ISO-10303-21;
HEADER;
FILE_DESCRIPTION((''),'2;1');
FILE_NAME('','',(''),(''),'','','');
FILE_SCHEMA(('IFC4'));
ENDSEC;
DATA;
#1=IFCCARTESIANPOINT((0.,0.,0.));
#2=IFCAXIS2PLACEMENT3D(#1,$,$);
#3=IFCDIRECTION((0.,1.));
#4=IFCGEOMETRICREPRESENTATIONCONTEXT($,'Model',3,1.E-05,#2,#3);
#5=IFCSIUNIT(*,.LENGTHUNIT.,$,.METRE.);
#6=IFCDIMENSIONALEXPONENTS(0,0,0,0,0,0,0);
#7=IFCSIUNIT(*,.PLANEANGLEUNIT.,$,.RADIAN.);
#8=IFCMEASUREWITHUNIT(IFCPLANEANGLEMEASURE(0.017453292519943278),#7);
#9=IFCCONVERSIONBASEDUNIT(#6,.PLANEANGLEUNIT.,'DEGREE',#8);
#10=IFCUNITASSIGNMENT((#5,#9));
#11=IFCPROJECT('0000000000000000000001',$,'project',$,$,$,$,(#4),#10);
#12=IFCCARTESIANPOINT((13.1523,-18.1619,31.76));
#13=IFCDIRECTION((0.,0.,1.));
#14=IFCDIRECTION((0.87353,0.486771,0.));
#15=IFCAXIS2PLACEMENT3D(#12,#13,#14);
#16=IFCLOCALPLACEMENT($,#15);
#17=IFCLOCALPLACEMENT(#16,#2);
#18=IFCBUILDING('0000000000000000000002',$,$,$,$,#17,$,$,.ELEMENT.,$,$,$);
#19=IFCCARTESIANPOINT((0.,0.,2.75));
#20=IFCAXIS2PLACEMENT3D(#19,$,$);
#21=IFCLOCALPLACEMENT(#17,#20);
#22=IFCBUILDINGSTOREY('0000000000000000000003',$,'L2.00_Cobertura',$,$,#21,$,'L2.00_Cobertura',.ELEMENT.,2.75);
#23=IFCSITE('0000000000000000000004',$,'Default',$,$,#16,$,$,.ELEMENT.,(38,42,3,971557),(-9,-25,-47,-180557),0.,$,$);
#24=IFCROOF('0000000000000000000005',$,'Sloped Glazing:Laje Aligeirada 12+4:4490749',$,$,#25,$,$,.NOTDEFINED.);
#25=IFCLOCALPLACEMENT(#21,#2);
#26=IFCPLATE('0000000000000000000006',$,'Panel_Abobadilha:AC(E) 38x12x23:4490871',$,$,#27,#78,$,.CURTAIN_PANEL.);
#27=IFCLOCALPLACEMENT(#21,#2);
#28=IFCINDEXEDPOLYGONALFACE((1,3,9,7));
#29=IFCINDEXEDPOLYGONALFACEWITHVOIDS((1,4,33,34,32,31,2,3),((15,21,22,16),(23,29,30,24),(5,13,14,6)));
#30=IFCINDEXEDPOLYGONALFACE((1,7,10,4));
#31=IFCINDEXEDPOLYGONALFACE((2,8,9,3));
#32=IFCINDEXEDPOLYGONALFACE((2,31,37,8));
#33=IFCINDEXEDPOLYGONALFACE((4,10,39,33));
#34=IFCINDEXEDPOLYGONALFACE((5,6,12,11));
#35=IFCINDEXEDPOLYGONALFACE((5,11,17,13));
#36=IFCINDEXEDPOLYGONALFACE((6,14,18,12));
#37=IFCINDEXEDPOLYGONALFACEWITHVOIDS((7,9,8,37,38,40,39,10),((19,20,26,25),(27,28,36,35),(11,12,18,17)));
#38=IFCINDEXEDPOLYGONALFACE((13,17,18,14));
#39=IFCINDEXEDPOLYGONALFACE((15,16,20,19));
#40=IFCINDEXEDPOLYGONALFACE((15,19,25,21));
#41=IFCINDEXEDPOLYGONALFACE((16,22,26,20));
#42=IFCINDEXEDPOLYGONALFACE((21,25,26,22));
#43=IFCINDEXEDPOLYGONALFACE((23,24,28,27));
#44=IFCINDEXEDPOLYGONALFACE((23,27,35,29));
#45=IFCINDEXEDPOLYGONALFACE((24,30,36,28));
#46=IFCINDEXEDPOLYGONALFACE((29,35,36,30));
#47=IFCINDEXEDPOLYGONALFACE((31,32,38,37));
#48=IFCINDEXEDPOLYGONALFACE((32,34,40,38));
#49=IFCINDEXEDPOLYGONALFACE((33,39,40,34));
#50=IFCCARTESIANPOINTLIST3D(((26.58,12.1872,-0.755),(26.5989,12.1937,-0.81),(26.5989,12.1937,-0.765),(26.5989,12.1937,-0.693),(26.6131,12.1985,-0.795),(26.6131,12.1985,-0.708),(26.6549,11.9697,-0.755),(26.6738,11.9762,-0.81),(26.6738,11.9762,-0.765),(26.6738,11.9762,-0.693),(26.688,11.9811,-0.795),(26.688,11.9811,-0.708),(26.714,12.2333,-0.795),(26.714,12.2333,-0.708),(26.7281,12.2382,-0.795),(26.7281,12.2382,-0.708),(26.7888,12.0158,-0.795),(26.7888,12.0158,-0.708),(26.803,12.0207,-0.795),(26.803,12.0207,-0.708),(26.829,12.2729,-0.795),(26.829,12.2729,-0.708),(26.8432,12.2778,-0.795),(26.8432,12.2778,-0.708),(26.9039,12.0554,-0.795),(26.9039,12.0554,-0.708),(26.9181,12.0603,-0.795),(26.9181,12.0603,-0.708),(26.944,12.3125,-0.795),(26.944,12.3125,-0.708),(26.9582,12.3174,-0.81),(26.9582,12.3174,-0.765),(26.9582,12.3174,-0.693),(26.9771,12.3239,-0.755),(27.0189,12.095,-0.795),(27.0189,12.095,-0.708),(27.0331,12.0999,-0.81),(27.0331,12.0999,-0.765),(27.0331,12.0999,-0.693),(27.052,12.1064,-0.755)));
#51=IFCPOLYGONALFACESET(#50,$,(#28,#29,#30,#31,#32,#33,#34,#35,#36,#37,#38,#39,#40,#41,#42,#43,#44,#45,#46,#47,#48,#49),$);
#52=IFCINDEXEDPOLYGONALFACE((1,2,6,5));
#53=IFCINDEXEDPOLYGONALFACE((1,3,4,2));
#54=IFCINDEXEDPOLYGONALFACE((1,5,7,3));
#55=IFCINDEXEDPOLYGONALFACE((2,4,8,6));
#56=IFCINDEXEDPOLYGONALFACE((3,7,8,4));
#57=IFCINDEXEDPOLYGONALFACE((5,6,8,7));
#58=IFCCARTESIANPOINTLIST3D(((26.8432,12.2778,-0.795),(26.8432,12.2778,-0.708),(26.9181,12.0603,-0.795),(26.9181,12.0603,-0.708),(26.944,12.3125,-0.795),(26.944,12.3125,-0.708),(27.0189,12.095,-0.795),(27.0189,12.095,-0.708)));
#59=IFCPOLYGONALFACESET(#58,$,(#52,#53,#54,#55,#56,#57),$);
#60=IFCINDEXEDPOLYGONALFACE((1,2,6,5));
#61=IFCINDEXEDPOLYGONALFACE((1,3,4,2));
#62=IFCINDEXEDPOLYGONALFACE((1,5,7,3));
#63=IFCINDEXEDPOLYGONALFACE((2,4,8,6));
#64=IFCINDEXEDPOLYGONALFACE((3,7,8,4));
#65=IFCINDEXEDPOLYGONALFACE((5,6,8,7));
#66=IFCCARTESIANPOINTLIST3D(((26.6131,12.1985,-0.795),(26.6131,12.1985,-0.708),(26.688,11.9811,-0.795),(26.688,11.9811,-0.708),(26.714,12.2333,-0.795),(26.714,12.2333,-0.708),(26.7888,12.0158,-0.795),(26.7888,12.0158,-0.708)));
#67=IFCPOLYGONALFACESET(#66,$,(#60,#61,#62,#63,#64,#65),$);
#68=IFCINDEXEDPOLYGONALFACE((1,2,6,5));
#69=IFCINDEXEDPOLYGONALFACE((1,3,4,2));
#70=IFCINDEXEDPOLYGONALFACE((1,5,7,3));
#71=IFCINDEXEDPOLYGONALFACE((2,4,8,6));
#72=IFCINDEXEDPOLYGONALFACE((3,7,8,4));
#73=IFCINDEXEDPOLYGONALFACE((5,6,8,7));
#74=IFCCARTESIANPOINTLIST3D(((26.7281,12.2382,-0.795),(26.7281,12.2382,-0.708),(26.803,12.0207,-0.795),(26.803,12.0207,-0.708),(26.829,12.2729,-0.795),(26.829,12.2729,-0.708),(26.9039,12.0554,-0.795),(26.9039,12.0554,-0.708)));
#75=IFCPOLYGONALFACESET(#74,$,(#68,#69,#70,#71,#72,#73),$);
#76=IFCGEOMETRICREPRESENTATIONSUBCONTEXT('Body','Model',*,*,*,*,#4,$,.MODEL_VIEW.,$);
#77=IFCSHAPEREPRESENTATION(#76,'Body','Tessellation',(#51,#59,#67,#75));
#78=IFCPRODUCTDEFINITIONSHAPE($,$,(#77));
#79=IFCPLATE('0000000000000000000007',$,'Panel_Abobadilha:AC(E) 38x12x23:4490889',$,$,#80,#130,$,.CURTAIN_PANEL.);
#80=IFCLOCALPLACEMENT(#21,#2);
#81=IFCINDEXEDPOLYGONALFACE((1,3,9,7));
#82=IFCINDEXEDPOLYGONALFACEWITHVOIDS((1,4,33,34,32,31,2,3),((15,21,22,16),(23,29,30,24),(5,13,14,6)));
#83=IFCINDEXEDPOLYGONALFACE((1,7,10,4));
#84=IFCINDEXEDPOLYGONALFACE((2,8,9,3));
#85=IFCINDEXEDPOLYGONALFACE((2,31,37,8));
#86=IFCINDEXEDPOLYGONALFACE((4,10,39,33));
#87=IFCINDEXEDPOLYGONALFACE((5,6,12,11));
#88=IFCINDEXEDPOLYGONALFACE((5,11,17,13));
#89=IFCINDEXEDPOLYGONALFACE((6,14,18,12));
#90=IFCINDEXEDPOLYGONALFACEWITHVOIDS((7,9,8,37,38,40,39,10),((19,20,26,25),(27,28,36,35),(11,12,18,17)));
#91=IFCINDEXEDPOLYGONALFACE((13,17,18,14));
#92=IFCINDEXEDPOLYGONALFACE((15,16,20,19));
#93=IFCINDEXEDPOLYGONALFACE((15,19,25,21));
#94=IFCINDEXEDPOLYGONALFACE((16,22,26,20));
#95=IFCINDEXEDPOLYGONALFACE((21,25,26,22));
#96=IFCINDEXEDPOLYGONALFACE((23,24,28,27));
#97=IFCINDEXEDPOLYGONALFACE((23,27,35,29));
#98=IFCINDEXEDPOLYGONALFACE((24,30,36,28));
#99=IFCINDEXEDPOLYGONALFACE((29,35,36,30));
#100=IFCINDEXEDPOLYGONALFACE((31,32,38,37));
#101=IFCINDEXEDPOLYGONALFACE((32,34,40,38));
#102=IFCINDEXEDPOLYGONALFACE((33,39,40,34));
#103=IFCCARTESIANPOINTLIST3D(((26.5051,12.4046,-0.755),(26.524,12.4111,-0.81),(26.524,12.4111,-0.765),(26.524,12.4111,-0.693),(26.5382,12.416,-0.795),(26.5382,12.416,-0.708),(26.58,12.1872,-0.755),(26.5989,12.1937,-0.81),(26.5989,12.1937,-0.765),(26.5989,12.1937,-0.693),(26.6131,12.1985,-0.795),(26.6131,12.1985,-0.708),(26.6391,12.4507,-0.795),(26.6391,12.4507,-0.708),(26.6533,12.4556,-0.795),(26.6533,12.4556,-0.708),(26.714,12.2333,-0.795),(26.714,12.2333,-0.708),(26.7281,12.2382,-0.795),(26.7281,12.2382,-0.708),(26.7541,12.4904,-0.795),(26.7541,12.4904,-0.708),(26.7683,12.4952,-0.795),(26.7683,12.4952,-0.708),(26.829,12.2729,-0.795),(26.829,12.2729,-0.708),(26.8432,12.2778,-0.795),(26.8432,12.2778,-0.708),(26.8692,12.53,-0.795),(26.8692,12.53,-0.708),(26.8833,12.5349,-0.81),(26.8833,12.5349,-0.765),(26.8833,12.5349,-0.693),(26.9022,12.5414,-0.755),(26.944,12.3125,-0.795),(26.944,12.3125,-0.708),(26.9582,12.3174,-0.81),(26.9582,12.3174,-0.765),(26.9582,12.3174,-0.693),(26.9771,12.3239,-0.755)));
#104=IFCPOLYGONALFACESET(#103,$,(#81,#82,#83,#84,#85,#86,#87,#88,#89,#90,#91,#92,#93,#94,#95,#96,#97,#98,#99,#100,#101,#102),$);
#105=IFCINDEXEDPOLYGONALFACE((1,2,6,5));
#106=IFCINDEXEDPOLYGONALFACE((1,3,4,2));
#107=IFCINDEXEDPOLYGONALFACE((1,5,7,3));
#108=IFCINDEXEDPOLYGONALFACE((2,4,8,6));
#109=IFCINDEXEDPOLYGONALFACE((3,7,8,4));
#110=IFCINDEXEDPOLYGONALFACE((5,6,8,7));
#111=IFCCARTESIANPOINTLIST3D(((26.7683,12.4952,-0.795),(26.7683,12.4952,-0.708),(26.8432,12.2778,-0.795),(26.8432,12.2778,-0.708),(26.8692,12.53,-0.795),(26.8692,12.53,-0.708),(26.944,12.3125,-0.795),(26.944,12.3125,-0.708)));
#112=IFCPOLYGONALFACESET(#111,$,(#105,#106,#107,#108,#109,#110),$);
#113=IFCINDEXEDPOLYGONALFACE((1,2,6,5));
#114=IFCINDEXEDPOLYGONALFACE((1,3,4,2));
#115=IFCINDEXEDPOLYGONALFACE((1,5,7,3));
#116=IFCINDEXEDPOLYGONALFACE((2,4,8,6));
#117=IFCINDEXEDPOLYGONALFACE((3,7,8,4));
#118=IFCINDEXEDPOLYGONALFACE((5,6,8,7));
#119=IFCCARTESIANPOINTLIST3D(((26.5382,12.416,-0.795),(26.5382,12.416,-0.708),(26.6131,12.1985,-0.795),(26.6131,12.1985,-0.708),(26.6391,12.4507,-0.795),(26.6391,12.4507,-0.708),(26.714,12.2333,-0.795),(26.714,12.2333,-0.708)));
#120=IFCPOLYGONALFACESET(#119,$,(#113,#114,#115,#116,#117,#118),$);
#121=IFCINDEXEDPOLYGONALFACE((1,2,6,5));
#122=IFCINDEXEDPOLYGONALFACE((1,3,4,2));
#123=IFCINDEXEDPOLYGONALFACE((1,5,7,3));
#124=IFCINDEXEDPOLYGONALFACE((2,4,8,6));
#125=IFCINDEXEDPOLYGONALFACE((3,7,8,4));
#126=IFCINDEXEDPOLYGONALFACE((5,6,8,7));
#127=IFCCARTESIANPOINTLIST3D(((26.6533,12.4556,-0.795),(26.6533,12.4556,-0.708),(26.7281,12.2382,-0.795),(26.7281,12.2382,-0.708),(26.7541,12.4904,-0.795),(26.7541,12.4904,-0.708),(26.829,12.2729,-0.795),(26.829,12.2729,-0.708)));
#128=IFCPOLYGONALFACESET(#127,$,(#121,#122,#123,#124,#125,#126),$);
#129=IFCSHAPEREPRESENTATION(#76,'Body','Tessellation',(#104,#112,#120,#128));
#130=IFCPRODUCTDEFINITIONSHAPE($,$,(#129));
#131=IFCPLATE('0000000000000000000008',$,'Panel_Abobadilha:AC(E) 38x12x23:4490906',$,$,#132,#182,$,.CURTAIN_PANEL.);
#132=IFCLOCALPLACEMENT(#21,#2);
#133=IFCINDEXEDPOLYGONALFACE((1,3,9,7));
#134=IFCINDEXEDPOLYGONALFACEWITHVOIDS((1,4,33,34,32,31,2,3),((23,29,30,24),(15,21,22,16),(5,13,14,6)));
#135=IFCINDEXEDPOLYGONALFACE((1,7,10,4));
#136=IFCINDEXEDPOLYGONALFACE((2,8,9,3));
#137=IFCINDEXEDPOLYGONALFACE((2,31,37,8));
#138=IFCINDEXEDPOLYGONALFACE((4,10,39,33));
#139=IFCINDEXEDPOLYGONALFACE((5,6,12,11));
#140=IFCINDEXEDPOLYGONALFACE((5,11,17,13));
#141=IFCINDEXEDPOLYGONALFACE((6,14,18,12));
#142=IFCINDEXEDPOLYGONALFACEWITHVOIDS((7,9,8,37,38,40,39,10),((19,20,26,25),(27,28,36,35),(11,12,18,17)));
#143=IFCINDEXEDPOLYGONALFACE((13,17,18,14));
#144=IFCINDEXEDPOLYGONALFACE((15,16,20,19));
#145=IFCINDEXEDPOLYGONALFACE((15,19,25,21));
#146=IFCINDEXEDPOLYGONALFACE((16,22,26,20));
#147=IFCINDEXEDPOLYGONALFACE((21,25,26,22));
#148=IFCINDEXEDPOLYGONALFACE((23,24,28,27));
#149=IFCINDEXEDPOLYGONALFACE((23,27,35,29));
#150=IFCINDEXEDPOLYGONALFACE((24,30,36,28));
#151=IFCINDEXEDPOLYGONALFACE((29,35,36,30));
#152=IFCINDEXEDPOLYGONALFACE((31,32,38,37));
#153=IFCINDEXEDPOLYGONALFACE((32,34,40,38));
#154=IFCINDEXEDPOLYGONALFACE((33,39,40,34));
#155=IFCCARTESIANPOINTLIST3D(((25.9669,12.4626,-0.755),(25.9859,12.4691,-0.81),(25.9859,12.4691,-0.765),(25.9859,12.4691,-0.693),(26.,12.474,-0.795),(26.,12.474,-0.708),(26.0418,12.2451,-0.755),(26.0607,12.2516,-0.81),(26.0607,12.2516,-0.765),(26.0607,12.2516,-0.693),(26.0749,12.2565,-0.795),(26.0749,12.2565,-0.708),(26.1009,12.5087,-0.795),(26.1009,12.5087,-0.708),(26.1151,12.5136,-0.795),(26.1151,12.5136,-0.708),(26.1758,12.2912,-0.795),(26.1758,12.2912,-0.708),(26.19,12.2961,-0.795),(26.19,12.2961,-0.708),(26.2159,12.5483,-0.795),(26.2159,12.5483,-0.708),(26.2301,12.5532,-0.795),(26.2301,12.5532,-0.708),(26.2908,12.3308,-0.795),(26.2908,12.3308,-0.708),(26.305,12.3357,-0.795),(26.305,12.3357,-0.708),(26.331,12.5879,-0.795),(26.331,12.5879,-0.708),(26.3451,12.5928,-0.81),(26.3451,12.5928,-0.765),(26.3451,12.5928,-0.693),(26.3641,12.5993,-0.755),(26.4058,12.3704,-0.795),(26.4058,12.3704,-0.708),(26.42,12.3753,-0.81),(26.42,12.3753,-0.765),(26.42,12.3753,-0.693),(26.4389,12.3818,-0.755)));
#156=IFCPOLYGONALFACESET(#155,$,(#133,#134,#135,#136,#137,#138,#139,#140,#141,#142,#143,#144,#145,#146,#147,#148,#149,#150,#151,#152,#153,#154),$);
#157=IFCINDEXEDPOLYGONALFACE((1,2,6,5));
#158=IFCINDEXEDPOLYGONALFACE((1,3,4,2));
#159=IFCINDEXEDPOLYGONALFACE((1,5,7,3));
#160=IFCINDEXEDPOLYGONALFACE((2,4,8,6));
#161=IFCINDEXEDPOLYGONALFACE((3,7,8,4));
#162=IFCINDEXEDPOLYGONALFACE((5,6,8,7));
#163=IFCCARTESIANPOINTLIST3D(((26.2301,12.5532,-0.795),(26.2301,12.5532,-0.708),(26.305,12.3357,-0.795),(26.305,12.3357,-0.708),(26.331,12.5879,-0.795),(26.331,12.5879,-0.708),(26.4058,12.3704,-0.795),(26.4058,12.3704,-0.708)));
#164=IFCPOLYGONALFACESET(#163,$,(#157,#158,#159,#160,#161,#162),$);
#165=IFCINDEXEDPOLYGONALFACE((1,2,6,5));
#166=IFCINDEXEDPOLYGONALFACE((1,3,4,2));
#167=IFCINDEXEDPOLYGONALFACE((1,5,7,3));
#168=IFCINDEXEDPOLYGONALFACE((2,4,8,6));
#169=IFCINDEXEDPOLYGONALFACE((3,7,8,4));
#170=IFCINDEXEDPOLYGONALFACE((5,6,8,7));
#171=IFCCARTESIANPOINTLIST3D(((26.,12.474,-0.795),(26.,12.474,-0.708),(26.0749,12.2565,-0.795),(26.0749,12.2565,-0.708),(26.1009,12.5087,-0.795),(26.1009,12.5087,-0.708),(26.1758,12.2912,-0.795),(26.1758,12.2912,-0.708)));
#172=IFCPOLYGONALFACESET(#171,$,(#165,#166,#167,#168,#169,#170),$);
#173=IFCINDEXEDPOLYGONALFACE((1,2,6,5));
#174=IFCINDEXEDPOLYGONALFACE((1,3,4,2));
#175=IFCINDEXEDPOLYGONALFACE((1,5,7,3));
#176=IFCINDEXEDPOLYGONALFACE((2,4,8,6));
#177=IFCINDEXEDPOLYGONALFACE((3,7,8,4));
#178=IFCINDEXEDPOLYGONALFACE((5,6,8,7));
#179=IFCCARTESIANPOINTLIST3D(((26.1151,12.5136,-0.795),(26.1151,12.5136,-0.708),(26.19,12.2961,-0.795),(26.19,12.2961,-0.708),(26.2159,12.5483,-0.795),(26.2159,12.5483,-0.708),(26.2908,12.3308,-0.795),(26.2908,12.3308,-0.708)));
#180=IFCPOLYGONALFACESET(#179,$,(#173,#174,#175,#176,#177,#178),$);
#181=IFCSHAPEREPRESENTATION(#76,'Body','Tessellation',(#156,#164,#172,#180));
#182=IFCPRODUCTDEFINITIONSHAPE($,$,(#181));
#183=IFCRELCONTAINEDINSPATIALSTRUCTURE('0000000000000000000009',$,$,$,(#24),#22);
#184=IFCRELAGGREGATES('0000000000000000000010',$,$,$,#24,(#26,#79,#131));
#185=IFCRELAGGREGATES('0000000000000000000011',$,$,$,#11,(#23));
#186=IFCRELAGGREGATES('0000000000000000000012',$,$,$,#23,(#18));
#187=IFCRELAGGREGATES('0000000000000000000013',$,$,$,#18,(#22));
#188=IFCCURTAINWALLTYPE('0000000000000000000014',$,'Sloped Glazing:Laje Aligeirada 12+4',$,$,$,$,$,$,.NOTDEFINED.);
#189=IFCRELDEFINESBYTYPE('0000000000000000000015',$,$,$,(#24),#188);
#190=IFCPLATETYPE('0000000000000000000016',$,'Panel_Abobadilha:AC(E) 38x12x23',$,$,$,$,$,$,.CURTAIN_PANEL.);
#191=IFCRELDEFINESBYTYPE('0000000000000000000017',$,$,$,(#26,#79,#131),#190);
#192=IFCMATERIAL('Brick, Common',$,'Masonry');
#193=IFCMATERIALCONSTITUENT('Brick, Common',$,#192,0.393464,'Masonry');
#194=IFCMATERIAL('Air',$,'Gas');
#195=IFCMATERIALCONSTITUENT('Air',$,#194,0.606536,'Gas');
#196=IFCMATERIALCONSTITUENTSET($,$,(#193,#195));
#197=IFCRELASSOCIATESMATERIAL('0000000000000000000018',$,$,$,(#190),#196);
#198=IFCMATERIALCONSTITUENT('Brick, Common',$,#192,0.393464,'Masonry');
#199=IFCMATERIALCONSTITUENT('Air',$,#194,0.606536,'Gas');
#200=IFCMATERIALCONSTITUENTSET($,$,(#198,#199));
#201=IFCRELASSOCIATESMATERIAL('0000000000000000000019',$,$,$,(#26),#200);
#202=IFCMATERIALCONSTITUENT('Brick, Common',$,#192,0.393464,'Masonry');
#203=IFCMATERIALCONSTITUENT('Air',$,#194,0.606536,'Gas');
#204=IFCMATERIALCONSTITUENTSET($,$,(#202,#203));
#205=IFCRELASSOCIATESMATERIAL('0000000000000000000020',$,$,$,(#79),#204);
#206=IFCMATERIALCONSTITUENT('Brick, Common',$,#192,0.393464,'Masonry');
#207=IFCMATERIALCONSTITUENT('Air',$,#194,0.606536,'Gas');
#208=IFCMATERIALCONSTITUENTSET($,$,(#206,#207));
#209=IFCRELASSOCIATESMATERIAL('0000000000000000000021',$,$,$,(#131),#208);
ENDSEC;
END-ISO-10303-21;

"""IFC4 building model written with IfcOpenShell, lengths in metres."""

from ifc_helpers import new_model, entity, si_unit, converted_unit, direction, frame, origin, place, context, subcontext, project, spatial, indexed_curve, outline, extrude, source, transform, mapped, material, constituent, constituent_set, type_object, type_shapes, element, aggregate, save


model = new_model("IFC4")

# Units and contexts
model_context = context("Model", 3, precision=1e-05, world=origin(), true_north=direction((0.0, 1.0)))
body_context = subcontext(model_context, "Body", "Model", "MODEL_VIEW")
ifc_project = project(units=[si_unit("LENGTHUNIT", "METRE"), converted_unit("PLANEANGLEUNIT", "DEGREE", entity("IfcPlaneAngleMeasure", 0.017453292519943278), si_unit("PLANEANGLEUNIT", "RADIAN"), dimensions=[0, 0, 0, 0, 0, 0, 0])], contexts=[model_context])

# Site, building, storey
site_placement = place(None, frame((13.1523, -18.1619, 31.76), z_axis=(0.0, 0.0, 1.0), x_axis=(0.87353, 0.486771, 0.0)))
site = spatial("IfcSite", under=ifc_project, at=site_placement, Name="Default", CompositionType="ELEMENT", RefLatitude=(38, 42, 3, 971557), RefLongitude=(-9, -25, -47, -180557), RefElevation=0.0)
building_placement = place(site_placement, origin())
building = spatial("IfcBuilding", under=site, at=building_placement, CompositionType="ELEMENT")
storey_placement = place(building_placement, frame((0.0, 0.0, 2.75)))
storey = spatial("IfcBuildingStorey", under=building, at=storey_placement, Name="L2.00_Cobertura", LongName="L2.00_Cobertura", CompositionType="ELEMENT", Elevation=2.75)

# Roof, plates
curtain_wall_type = type_object("IfcCurtainWallType", Name="Sloped Glazing:Laje Aligeirada 12+4", PredefinedType="NOTDEFINED")
roof_placement = place(storey_placement, frame((0.0, 0.0, -2.75)))
roof = element("IfcRoof", 1, at=roof_placement, inside=storey, type_object=curtain_wall_type, Name="Sloped Glazing:Laje Aligeirada 12+4:4490749", PredefinedType="NOTDEFINED")
ifc_material_1 = material(Name="Brick, Common", Category="Masonry")
ifc_constituent_1 = constituent(ifc_material_1, Name="Brick, Common", Category="Masonry", fraction=0.393464)
ifc_material_2 = material(Name="Air", Category="Gas")
ifc_constituent_2 = constituent(ifc_material_2, Name="Air", Category="Gas", fraction=0.606536)
ifc_constituent_set_1 = constituent_set(constituents=[ifc_constituent_1, ifc_constituent_2])
ifc_constituent_3 = constituent(ifc_material_1, Name="Brick, Common", Category="Masonry", fraction=0.393464)
ifc_constituent_4 = constituent(ifc_material_2, Name="Air", Category="Gas", fraction=0.606536)
ifc_constituent_set_2 = constituent_set(constituents=[ifc_constituent_3, ifc_constituent_4])
plate_type = type_object("IfcPlateType", Name="Panel_Abobadilha:AC(E) 38x12x23", PredefinedType="CURTAIN_PANEL", material=ifc_constituent_set_2)
shared_shape_1 = source(origin(), body_context, "Body", "SweptSolid", [
    extrude(outline(indexed_curve([(-0.19, -0.0543), (0.19, -0.0543), (0.19, -0.0093), (0.21, 0.0007), (0.19, 0.0628), (-0.19, 0.0628), (-0.21, 0.0007), (-0.19, -0.0093), (-0.19, -0.0543)], self_intersect=False), holes=[indexed_curve([(-0.0683, 0.0477), (-0.0683, -0.0393), (-0.175, -0.0393), (-0.175, 0.0477), (-0.0683, 0.0477)], self_intersect=False), indexed_curve([(0.0533, 0.0477), (0.0533, -0.0393), (-0.0533, -0.0393), (-0.0533, 0.0477), (0.0533, 0.0477)], self_intersect=False), indexed_curve([(0.175, 0.0477), (0.175, -0.0393), (0.0683, -0.0393), (0.0683, 0.0477), (0.175, 0.0477)], self_intersect=False)]), frame((0.0, 0.0543, 0.0)), (0.0, 0.0, 1.0), 0.23),
    extrude(outline(indexed_curve([(-0.0533, -0.0435), (0.0533, -0.0435), (0.0533, 0.0435), (-0.0533, 0.0435), (-0.0533, -0.0435)], self_intersect=False)), frame((0.1217, 0.0585, 0.0), z_axis=(0.0, 0.0, 1.0), x_axis=(-1.0, 0.0, 0.0)), (0.0, 0.0, 1.0), 0.23),
    extrude(outline(indexed_curve([(-0.0533, -0.0435), (0.0533, -0.0435), (0.0533, 0.0435), (-0.0533, 0.0435), (-0.0533, -0.0435)], self_intersect=False)), frame((-0.1217, 0.0585, 0.0), z_axis=(0.0, 0.0, 1.0), x_axis=(-1.0, 0.0, 0.0)), (0.0, 0.0, 1.0), 0.23),
    extrude(outline(indexed_curve([(-0.0533, -0.0435), (0.0533, -0.0435), (0.0533, 0.0435), (-0.0533, 0.0435), (-0.0533, -0.0435)], self_intersect=False)), frame((0.0, 0.0585, 0.0), z_axis=(0.0, 0.0, 1.0), x_axis=(-1.0, 0.0, 0.0)), (0.0, 0.0, 1.0), 0.23),
])
type_shapes(plate_type, [shared_shape_1])
plate_1_placement = place(roof_placement, frame((26.7786, 12.2555, 1.94), z_axis=(0.325568, -0.945519, 0.0), x_axis=(0.945519, 0.325568, 0.0)))
plate_1 = element("IfcPlate", 2, at=plate_1_placement, type_object=plate_type, material=ifc_constituent_set_1, Name="Panel_Abobadilha:AC(E) 38x12x23:4490871", PredefinedType="CURTAIN_PANEL", context=body_context, shape_type="MappedRepresentation", body=[
    mapped(shared_shape_1, transform((0.0, 0.0, 0.0), scale=1.0)),
])
ifc_constituent_5 = constituent(ifc_material_1, Name="Brick, Common", Category="Masonry", fraction=0.393464)
ifc_constituent_6 = constituent(ifc_material_2, Name="Air", Category="Gas", fraction=0.606536)
ifc_constituent_set_3 = constituent_set(constituents=[ifc_constituent_5, ifc_constituent_6])
plate_2_placement = place(roof_placement, frame((26.7037, 12.473, 1.94), z_axis=(0.325568, -0.945519, 0.0), x_axis=(0.945519, 0.325568, 0.0)))
plate_2 = element("IfcPlate", 3, at=plate_2_placement, type_object=plate_type, material=ifc_constituent_set_3, Name="Panel_Abobadilha:AC(E) 38x12x23:4490889", PredefinedType="CURTAIN_PANEL", context=body_context, shape_type="MappedRepresentation", body=[
    mapped(shared_shape_1, transform((0.0, 0.0, 0.0), scale=1.0)),
])
ifc_constituent_7 = constituent(ifc_material_1, Name="Brick, Common", Category="Masonry", fraction=0.393464)
ifc_constituent_8 = constituent(ifc_material_2, Name="Air", Category="Gas", fraction=0.606536)
ifc_constituent_set_4 = constituent_set(constituents=[ifc_constituent_7, ifc_constituent_8])
plate_3_placement = place(roof_placement, frame((26.1655, 12.5309, 1.94), z_axis=(0.325568, -0.945519, 0.0), x_axis=(0.945519, 0.325568, 0.0)))
plate_3 = element("IfcPlate", 4, at=plate_3_placement, type_object=plate_type, material=ifc_constituent_set_4, Name="Panel_Abobadilha:AC(E) 38x12x23:4490906", PredefinedType="CURTAIN_PANEL", context=body_context, shape_type="MappedRepresentation", body=[
    mapped(shared_shape_1, transform((0.0, 0.0, 0.0), scale=1.0)),
])
aggregate(roof, [plate_1, plate_2, plate_3])

save(model, "model.ifc")
